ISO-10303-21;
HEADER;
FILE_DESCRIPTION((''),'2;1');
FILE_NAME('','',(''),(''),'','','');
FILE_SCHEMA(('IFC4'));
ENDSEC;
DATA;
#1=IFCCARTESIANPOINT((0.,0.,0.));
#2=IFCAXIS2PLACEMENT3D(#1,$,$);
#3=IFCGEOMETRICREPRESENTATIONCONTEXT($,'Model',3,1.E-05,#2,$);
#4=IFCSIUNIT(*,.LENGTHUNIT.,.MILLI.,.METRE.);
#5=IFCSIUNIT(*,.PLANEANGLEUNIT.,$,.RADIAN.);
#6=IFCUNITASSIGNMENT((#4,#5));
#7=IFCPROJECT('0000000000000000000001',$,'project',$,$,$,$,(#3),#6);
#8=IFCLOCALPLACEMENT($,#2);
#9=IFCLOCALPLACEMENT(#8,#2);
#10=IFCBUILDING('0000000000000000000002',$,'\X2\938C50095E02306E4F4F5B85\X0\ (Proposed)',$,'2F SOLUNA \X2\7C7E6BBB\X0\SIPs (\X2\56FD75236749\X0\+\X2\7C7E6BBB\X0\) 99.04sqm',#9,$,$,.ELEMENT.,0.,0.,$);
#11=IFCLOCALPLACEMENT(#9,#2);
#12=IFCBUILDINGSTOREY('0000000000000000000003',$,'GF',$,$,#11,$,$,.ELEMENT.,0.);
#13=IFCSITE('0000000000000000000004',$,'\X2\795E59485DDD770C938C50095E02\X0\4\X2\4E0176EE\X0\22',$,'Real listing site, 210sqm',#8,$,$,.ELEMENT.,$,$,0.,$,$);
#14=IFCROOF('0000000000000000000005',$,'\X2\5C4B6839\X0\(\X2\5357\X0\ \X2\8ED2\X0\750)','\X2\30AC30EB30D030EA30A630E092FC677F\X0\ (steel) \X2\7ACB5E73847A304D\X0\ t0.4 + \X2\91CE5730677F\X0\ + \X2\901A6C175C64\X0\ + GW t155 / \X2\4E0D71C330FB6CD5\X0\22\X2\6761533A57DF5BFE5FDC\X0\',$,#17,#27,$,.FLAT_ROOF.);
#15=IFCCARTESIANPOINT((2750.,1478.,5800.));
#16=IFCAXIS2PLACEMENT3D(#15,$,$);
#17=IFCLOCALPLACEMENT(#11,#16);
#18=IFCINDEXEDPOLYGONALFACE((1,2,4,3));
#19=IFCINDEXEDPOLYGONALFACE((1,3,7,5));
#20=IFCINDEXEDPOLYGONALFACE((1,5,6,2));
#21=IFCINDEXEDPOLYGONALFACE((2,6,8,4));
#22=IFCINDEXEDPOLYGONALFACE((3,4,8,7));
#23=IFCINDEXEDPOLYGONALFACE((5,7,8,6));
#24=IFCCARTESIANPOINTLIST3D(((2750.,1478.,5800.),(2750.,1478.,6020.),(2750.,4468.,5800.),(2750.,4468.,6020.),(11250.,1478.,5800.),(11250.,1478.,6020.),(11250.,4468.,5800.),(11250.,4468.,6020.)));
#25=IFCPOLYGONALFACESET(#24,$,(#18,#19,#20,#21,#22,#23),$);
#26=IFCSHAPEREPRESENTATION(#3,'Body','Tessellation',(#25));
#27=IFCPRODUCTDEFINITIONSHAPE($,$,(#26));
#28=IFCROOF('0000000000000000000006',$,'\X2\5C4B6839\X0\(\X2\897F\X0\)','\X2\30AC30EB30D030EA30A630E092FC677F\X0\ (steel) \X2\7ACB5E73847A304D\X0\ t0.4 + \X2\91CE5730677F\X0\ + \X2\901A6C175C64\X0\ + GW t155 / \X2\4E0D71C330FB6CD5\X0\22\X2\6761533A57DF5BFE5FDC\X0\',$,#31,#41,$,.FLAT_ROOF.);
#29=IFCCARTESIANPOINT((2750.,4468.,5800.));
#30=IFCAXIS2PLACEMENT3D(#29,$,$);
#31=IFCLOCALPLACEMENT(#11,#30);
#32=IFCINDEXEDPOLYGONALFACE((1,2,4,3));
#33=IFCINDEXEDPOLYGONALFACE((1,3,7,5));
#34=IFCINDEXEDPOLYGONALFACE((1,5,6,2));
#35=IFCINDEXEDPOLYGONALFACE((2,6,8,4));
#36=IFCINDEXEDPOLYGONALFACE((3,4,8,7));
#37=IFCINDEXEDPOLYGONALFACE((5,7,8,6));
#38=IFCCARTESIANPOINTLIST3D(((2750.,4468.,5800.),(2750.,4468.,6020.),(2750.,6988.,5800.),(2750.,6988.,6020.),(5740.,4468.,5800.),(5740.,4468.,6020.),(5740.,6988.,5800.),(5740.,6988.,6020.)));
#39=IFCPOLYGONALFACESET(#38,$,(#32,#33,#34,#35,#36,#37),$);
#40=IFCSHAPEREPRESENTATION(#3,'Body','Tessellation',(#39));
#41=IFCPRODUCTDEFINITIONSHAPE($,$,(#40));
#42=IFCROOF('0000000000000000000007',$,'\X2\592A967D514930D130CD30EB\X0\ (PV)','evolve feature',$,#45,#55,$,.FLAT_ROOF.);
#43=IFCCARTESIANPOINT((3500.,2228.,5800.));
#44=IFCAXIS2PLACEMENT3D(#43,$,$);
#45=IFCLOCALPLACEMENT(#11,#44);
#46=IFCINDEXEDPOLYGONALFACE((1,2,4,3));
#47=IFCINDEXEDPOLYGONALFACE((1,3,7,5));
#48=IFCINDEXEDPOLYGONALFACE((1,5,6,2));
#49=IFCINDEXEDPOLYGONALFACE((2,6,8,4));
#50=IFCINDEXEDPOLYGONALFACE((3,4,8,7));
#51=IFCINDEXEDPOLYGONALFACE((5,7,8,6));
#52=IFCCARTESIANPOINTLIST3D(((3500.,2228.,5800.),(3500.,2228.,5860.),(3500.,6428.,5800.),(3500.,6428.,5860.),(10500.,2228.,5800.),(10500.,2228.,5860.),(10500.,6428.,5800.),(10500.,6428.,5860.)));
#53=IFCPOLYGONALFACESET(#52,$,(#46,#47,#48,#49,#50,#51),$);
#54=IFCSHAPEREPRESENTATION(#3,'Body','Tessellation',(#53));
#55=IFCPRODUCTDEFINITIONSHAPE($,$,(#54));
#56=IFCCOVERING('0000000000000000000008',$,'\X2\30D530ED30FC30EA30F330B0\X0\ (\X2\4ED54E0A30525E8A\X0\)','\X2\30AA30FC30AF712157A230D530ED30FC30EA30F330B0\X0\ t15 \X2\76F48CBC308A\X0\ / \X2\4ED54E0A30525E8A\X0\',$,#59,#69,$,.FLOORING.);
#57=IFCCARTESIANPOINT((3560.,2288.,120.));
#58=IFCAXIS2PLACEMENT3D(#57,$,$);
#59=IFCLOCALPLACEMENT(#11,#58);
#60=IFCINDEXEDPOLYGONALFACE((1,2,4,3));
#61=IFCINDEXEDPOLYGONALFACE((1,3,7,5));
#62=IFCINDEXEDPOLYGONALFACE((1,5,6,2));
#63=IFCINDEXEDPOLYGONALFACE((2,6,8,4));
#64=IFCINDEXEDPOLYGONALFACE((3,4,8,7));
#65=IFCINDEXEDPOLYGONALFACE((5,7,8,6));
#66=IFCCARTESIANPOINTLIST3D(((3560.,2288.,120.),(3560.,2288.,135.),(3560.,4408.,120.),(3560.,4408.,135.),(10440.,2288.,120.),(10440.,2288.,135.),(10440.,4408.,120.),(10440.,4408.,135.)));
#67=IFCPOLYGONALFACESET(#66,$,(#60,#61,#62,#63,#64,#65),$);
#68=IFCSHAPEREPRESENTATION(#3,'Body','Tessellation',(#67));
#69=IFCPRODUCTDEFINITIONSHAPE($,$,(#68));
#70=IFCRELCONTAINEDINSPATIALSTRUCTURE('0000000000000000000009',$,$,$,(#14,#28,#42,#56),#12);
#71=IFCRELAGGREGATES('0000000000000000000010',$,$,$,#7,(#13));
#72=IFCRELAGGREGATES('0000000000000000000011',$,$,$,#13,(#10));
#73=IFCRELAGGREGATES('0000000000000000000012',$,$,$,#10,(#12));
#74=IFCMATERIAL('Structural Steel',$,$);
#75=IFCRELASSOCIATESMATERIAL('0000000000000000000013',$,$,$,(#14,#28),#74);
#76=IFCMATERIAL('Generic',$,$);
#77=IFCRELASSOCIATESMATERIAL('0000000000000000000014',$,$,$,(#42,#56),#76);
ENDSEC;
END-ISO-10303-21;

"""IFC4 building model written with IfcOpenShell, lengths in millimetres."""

from ifc_helpers import new_model, si_unit, frame, frame_2d, origin, place, context, project, spatial, rectangle, extrude, material, element, save


model = new_model("IFC4")

# Units and contexts
model_context = context("Model", 3, precision=1e-05, world=origin())
ifc_project = project(units=[si_unit("LENGTHUNIT", "METRE", prefix="MILLI"), si_unit("PLANEANGLEUNIT", "RADIAN")], contexts=[model_context])

# Site, building, storey
site_placement = place(None, origin())
site = spatial("IfcSite", under=ifc_project, at=site_placement, Name="神奈川県鎌倉市4丁目22", ObjectType="Real listing site, 210sqm", CompositionType="ELEMENT", RefElevation=0.0)
building_placement = place(site_placement, origin())
building = spatial("IfcBuilding", under=site, at=building_placement, Name="鎌倉市の住宅 (Proposed)", ObjectType="2F SOLUNA 籾殻SIPs (国産杉+籾殻) 99.04sqm", CompositionType="ELEMENT", ElevationOfRefHeight=0.0, ElevationOfTerrain=0.0)
storey_placement = place(building_placement, origin())
storey = spatial("IfcBuildingStorey", under=building, at=storey_placement, Name="GF", CompositionType="ELEMENT", Elevation=0.0)

# Shared definitions
ifc_material_1 = material(Name="Generic")

# Roofs
ifc_material_2 = material(Name="Structural Steel")
roof_1_placement = place(storey_placement, frame((2750.0, 1478.0, 5800.0)))
element("IfcRoof", 1, at=roof_1_placement, inside=storey, material=ifc_material_2, Name="屋根(南 軒750)", Description="ガルバリウム鋼板 (steel) 立平葺き t0.4 + 野地板 + 通気層 + GW t155 / 不燃・法22条区域対応", PredefinedType="FLAT_ROOF", context=model_context, shape_type="SweptSolid", body=[
    extrude(rectangle(XDim=8500.0, YDim=2990.0, at=frame_2d((4250.0, 1495.0))), frame((2750.0, 1478.0, 5800.0)), (0.0, 0.0, 1.0), 220.0),
])
roof_2_placement = place(storey_placement, frame((2750.0, 4468.0, 5800.0)))
element("IfcRoof", 2, at=roof_2_placement, inside=storey, material=ifc_material_2, Name="屋根(西)", Description="ガルバリウム鋼板 (steel) 立平葺き t0.4 + 野地板 + 通気層 + GW t155 / 不燃・法22条区域対応", PredefinedType="FLAT_ROOF", context=model_context, shape_type="SweptSolid", body=[
    extrude(rectangle(XDim=2990.0, YDim=2520.0, at=frame_2d((1495.0, 1260.0))), frame((2750.0, 4468.0, 5800.0)), (0.0, 0.0, 1.0), 220.0),
])
roof_3_placement = place(storey_placement, frame((3500.0, 2228.0, 5800.0)))
element("IfcRoof", 3, at=roof_3_placement, inside=storey, material=ifc_material_1, Name="太陽光パネル (PV)", Description="evolve feature", PredefinedType="FLAT_ROOF", context=model_context, shape_type="SweptSolid", body=[
    extrude(rectangle(XDim=7000.0, YDim=4200.0, at=frame_2d((3500.0, 2100.0))), frame((3500.0, 2228.0, 5800.0)), (0.0, 0.0, 1.0), 60.0),
])

# Covering
covering_placement = place(storey_placement, frame((3560.0, 2288.0, 120.0)))
element("IfcCovering", 4, at=covering_placement, inside=storey, material=ifc_material_1, Name="フローリング (仕上げ床)", Description="オーク無垢フローリング t15 直貼り / 仕上げ床", PredefinedType="FLOORING", context=model_context, shape_type="SweptSolid", body=[
    extrude(rectangle(XDim=6880.0, YDim=2120.0, at=frame_2d((3440.0, 1060.0))), frame((3560.0, 2288.0, 120.0)), (0.0, 0.0, 1.0), 15.0),
])

save(model, "model.ifc")
